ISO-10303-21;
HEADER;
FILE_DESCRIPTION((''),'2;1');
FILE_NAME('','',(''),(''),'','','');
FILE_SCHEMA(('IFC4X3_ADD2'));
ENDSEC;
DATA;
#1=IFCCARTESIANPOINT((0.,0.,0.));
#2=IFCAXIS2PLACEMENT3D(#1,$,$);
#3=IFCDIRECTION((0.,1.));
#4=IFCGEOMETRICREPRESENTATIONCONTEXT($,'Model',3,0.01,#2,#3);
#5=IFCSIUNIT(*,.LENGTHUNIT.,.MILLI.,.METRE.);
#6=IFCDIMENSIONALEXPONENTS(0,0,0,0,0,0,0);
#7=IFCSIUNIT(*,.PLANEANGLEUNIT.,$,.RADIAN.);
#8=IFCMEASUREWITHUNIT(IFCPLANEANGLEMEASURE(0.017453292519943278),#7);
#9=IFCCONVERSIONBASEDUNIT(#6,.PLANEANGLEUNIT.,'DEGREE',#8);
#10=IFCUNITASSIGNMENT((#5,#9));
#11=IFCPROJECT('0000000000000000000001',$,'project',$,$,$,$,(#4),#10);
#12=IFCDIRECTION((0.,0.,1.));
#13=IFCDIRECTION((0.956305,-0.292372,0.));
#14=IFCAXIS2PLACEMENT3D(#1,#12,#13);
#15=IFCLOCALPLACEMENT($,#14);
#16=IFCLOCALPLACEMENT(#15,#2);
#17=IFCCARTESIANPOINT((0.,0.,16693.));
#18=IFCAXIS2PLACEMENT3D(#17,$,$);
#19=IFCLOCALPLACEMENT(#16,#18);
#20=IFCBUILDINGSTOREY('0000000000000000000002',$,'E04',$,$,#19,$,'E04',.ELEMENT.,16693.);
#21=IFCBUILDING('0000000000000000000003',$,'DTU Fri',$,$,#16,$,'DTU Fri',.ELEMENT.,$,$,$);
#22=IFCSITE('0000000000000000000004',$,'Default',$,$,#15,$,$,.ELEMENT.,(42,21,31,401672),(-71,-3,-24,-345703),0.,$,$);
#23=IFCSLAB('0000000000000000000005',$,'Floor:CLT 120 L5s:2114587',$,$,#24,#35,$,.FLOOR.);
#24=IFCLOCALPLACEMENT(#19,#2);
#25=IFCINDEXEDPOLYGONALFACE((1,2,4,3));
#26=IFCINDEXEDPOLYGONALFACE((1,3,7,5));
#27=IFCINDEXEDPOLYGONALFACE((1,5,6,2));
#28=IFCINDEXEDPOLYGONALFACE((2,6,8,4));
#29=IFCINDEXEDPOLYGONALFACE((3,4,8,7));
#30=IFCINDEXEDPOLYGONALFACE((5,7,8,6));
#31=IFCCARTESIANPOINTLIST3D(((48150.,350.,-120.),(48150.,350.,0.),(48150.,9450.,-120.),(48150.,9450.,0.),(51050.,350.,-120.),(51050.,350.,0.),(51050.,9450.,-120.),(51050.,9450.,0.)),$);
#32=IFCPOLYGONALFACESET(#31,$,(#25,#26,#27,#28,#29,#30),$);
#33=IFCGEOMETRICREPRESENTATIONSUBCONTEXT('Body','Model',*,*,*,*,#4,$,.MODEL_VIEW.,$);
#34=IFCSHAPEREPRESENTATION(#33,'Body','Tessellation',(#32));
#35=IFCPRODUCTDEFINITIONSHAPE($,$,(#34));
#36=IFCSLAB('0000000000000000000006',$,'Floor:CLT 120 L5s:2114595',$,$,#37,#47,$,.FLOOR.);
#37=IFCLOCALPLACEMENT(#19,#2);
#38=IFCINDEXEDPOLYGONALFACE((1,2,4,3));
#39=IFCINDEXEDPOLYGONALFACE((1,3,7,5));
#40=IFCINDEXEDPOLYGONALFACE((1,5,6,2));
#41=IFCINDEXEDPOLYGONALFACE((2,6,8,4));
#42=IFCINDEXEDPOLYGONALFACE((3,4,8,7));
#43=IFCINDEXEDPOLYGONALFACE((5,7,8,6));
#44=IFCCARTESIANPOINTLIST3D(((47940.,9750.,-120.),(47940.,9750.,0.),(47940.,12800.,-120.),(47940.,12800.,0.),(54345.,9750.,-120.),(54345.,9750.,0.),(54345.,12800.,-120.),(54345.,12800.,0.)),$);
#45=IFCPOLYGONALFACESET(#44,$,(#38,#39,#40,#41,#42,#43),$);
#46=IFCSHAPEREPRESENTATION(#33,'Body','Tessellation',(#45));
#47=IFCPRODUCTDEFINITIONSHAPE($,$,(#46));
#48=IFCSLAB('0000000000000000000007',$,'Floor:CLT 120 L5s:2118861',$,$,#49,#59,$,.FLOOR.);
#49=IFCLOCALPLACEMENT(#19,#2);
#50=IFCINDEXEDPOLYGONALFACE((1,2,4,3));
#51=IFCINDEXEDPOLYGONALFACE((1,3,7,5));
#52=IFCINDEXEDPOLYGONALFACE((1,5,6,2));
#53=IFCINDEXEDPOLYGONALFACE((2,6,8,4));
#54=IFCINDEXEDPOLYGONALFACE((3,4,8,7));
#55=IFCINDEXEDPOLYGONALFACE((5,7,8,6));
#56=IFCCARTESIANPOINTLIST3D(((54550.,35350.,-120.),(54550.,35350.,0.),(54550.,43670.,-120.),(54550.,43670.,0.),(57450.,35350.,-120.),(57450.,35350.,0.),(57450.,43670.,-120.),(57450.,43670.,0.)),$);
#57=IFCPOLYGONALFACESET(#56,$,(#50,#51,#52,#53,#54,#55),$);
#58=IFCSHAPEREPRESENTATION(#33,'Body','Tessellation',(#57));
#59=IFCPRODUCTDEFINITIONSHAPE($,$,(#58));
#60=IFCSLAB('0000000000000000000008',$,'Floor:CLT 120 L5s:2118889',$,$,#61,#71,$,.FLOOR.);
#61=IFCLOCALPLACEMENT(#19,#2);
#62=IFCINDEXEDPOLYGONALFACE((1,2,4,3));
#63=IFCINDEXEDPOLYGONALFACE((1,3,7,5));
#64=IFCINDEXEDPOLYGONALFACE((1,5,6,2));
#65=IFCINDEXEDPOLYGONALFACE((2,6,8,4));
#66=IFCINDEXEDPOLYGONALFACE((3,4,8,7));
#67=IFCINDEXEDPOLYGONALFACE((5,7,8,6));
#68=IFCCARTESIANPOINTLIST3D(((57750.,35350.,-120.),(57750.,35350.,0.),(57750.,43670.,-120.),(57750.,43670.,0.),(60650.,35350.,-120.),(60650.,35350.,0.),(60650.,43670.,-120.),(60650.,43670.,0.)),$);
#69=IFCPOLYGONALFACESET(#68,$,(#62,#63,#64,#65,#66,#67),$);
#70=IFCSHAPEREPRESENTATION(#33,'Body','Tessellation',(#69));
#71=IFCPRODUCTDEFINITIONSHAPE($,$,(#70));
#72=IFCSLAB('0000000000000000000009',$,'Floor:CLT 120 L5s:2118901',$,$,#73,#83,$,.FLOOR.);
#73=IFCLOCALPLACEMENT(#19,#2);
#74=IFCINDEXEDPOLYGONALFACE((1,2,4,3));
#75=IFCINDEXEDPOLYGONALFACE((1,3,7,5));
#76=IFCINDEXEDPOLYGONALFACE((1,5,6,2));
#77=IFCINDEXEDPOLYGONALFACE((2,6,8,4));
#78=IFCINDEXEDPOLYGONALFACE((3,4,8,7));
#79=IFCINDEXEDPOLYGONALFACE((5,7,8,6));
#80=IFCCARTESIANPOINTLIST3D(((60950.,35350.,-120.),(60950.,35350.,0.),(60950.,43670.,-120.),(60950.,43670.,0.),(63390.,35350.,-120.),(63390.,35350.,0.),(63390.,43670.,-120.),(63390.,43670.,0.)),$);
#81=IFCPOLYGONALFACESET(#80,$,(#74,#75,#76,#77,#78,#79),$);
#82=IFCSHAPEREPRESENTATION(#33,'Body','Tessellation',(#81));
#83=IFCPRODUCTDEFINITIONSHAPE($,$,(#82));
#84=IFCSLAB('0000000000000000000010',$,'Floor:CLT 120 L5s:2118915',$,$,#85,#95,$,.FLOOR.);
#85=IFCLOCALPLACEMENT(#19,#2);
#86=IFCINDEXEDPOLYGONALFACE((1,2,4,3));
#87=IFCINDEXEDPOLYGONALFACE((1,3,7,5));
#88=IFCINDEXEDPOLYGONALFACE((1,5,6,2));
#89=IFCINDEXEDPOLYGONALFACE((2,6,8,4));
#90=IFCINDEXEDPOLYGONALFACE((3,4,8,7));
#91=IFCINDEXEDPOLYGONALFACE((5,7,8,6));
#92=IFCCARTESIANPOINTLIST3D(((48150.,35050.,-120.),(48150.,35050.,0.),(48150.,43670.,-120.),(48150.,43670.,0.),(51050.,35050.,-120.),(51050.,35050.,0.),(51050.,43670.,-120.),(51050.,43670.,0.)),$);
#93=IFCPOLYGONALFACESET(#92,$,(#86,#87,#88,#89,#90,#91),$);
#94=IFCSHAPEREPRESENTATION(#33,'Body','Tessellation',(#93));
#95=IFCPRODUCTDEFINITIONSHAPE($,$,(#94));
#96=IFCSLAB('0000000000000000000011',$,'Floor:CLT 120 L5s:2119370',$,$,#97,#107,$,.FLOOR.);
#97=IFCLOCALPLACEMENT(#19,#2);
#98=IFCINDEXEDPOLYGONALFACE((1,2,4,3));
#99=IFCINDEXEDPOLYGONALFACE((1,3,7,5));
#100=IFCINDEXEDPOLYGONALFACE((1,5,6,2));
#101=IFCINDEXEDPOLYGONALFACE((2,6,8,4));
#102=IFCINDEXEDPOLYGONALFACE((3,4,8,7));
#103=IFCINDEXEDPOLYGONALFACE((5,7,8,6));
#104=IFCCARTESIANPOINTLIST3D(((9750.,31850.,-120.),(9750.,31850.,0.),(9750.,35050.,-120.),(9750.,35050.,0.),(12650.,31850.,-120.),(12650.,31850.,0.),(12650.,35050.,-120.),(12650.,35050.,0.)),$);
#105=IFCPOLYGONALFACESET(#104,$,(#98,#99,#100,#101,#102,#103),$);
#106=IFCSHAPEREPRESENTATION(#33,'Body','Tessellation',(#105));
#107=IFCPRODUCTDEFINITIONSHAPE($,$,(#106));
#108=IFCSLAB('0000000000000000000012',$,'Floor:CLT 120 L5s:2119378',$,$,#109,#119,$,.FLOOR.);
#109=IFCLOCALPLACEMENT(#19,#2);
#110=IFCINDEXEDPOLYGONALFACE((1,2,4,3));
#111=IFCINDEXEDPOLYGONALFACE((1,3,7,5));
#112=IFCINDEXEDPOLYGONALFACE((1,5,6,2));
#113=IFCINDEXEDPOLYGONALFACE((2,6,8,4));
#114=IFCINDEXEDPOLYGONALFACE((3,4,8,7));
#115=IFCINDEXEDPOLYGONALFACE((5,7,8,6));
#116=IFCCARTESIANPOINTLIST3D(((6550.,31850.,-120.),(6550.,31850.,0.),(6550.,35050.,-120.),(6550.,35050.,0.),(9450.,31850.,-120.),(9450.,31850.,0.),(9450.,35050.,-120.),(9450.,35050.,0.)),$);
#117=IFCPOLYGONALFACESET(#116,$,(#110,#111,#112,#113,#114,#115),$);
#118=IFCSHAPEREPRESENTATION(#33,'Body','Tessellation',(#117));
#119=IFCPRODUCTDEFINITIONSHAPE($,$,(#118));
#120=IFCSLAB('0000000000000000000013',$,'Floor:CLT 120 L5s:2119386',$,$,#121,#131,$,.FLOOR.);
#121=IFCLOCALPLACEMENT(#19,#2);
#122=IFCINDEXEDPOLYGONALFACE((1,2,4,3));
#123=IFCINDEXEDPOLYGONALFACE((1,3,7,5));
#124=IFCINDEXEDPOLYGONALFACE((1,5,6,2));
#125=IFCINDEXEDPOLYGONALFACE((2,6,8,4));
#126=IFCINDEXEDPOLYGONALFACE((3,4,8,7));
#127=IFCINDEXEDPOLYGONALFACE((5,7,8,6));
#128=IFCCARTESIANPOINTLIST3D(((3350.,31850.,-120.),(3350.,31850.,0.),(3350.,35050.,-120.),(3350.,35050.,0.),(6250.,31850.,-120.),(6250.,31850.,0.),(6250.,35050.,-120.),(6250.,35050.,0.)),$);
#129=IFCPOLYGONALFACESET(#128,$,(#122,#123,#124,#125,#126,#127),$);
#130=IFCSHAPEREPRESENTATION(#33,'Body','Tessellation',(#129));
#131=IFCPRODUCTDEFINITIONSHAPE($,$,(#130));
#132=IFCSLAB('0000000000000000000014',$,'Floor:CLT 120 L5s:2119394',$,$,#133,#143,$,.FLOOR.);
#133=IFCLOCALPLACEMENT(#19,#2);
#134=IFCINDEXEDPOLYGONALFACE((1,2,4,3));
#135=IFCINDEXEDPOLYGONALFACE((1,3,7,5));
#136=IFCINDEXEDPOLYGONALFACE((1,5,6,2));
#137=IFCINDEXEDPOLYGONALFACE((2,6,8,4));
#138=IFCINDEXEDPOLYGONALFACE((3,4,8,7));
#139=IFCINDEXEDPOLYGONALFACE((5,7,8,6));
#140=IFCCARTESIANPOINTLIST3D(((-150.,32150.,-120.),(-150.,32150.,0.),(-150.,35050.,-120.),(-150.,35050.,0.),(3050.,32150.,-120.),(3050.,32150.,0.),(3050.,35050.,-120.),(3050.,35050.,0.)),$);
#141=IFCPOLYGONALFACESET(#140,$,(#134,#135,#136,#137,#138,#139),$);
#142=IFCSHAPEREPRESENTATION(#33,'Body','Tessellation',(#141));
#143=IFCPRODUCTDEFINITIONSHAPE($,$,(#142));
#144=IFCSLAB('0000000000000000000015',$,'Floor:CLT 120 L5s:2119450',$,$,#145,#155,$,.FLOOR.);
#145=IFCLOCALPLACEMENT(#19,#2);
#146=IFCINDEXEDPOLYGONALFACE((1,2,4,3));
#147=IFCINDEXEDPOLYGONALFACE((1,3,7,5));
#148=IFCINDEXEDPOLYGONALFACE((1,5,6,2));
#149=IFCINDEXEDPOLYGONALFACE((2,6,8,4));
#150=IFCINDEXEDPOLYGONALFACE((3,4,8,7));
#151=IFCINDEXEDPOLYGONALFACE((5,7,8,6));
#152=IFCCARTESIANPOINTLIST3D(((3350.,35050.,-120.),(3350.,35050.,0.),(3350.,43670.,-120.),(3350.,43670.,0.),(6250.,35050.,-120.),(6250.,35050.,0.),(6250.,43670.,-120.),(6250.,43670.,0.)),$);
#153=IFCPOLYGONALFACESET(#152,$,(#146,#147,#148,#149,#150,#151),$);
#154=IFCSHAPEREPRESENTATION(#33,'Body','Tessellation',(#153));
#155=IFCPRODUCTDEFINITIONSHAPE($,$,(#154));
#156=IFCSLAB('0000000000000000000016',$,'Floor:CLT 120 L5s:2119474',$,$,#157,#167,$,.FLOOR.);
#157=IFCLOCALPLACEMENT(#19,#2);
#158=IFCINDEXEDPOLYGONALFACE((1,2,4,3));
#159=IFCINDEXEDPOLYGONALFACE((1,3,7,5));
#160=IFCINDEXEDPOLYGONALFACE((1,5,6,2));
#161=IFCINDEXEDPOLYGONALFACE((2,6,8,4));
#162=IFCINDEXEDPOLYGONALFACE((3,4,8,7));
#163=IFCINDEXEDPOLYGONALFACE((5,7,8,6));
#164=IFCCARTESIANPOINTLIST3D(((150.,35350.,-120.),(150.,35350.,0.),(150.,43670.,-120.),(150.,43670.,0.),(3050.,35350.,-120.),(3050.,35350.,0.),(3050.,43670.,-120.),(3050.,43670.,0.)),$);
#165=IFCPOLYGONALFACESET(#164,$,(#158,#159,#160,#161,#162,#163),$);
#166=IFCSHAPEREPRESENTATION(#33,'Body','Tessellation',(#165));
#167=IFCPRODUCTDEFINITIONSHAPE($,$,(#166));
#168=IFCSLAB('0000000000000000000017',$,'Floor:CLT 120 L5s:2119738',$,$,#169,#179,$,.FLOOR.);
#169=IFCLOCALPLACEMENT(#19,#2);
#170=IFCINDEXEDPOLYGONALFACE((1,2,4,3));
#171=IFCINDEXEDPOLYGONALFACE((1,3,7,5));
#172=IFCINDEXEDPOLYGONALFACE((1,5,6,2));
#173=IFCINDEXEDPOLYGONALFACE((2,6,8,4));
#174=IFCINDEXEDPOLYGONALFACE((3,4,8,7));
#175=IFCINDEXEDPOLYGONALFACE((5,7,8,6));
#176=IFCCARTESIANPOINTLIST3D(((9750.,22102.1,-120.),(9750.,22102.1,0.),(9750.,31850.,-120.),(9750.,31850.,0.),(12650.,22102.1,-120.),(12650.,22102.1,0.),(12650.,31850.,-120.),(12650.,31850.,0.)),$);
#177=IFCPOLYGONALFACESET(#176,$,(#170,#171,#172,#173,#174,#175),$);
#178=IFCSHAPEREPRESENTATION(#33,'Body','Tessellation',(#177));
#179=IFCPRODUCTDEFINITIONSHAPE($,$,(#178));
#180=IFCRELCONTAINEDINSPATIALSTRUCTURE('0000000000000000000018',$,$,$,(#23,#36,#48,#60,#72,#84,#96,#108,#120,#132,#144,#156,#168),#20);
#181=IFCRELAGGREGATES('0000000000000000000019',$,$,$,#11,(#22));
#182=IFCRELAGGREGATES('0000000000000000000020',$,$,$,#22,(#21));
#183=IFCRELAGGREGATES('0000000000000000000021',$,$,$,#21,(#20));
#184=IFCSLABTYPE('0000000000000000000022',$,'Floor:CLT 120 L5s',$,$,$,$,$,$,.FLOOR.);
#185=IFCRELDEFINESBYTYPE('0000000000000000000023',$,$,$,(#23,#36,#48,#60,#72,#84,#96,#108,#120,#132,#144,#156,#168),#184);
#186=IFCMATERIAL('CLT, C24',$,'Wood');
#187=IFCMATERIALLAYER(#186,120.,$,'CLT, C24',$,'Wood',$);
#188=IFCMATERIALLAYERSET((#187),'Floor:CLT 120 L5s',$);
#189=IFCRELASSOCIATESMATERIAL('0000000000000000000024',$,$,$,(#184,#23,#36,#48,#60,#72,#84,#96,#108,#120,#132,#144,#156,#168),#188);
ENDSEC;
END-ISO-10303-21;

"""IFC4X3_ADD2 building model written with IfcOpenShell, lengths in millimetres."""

from ifc_helpers import new_model, entity, si_unit, converted_unit, direction, frame, frame_2d, origin, place, context, subcontext, project, spatial, rectangle, extrude, material, layer, layer_set, layer_usage, type_object, element, save


model = new_model("IFC4X3_ADD2")

# Units and contexts
model_context = context("Model", 3, precision=0.01, world=origin(), true_north=direction((0.0, 1.0)))
body_context = subcontext(model_context, "Body", "Model", "MODEL_VIEW")
ifc_project = project(units=[si_unit("LENGTHUNIT", "METRE", prefix="MILLI"), converted_unit("PLANEANGLEUNIT", "DEGREE", entity("IfcPlaneAngleMeasure", 0.017453292519943278), si_unit("PLANEANGLEUNIT", "RADIAN"), dimensions=[0, 0, 0, 0, 0, 0, 0])], contexts=[model_context])

# Site, building, storey
site_placement = place(None, frame((0.0, 0.0, 0.0), z_axis=(0.0, 0.0, 1.0), x_axis=(0.956305, -0.292372, 0.0)))
site = spatial("IfcSite", under=ifc_project, at=site_placement, Name="Default", CompositionType="ELEMENT", RefLatitude=(42, 21, 31, 401672), RefLongitude=(-71, -3, -24, -345703), RefElevation=0.0)
building_placement = place(site_placement, origin())
building = spatial("IfcBuilding", under=site, at=building_placement, Name="DTU Fri", LongName="DTU Fri", CompositionType="ELEMENT")
storey_placement = place(building_placement, frame((0.0, 0.0, 16693.0)))
storey = spatial("IfcBuildingStorey", under=building, at=storey_placement, Name="E04", LongName="E04", CompositionType="ELEMENT", Elevation=16693.0)

# Slabs
ifc_material = material(Name="CLT, C24", Category="Wood")
ifc_layer = layer(ifc_material, 120.0, Name="CLT, C24", Category="Wood")
ifc_layer_set = layer_set([ifc_layer], Name="Floor:CLT 120 L5s")
ifc_layer_usage_1 = layer_usage(ifc_layer_set, "AXIS3", "POSITIVE", 0.0)
slab_type = type_object("IfcSlabType", Name="Floor:CLT 120 L5s", PredefinedType="FLOOR", material=ifc_layer_set)
slab_1_placement = place(storey_placement, origin())
element("IfcSlab", 1, at=slab_1_placement, inside=storey, type_object=slab_type, material=ifc_layer_usage_1, Name="Floor:CLT 120 L5s:2114587", PredefinedType="FLOOR", context=body_context, shape_type="SweptSolid", body=[
    extrude(rectangle(XDim=9100.0, YDim=2900.0, at=frame_2d((0.0, 0.0), x_axis=(1.0, 0.0))), frame((49600.0, 4900.0, 0.0), z_axis=(0.0, 0.0, -1.0), x_axis=(0.0, 1.0, 0.0)), (0.0, 0.0, 1.0), 120.0),
])
ifc_layer_usage_2 = layer_usage(ifc_layer_set, "AXIS3", "POSITIVE", 0.0)
slab_2_placement = place(storey_placement, origin())
element("IfcSlab", 2, at=slab_2_placement, inside=storey, type_object=slab_type, material=ifc_layer_usage_2, Name="Floor:CLT 120 L5s:2114595", PredefinedType="FLOOR", context=body_context, shape_type="SweptSolid", body=[
    extrude(rectangle(XDim=3050.0, YDim=6405.0, at=frame_2d((0.0, 0.0), x_axis=(1.0, 0.0))), frame((51142.5, 11275.0, 0.0), z_axis=(0.0, 0.0, -1.0), x_axis=(0.0, 1.0, 0.0)), (0.0, 0.0, 1.0), 120.0),
])
ifc_layer_usage_3 = layer_usage(ifc_layer_set, "AXIS3", "POSITIVE", 0.0)
slab_3_placement = place(storey_placement, origin())
element("IfcSlab", 3, at=slab_3_placement, inside=storey, type_object=slab_type, material=ifc_layer_usage_3, Name="Floor:CLT 120 L5s:2118861", PredefinedType="FLOOR", context=body_context, shape_type="SweptSolid", body=[
    extrude(rectangle(XDim=8320.0, YDim=2900.0, at=frame_2d((0.0, 0.0), x_axis=(1.0, 0.0))), frame((56000.0, 39510.0, 0.0), z_axis=(0.0, 0.0, -1.0), x_axis=(0.0, 1.0, 0.0)), (0.0, 0.0, 1.0), 120.0),
])
ifc_layer_usage_4 = layer_usage(ifc_layer_set, "AXIS3", "POSITIVE", 0.0)
slab_4_placement = place(storey_placement, origin())
element("IfcSlab", 4, at=slab_4_placement, inside=storey, type_object=slab_type, material=ifc_layer_usage_4, Name="Floor:CLT 120 L5s:2118889", PredefinedType="FLOOR", context=body_context, shape_type="SweptSolid", body=[
    extrude(rectangle(XDim=8320.0, YDim=2900.0, at=frame_2d((0.0, 0.0), x_axis=(1.0, 0.0))), frame((59200.0, 39510.0, 0.0), z_axis=(0.0, 0.0, -1.0), x_axis=(0.0, 1.0, 0.0)), (0.0, 0.0, 1.0), 120.0),
])
ifc_layer_usage_5 = layer_usage(ifc_layer_set, "AXIS3", "POSITIVE", 0.0)
slab_5_placement = place(storey_placement, origin())
element("IfcSlab", 5, at=slab_5_placement, inside=storey, type_object=slab_type, material=ifc_layer_usage_5, Name="Floor:CLT 120 L5s:2118901", PredefinedType="FLOOR", context=body_context, shape_type="SweptSolid", body=[
    extrude(rectangle(XDim=8320.0, YDim=2440.0, at=frame_2d((0.0, 0.0), x_axis=(1.0, 0.0))), frame((62170.0, 39510.0, 0.0), z_axis=(0.0, 0.0, -1.0), x_axis=(0.0, 1.0, 0.0)), (0.0, 0.0, 1.0), 120.0),
])
ifc_layer_usage_6 = layer_usage(ifc_layer_set, "AXIS3", "POSITIVE", 0.0)
slab_6_placement = place(storey_placement, origin())
element("IfcSlab", 6, at=slab_6_placement, inside=storey, type_object=slab_type, material=ifc_layer_usage_6, Name="Floor:CLT 120 L5s:2118915", PredefinedType="FLOOR", context=body_context, shape_type="SweptSolid", body=[
    extrude(rectangle(XDim=8620.0, YDim=2900.0, at=frame_2d((0.0, 0.0), x_axis=(1.0, 0.0))), frame((49600.0, 39360.0, 0.0), z_axis=(0.0, 0.0, -1.0), x_axis=(0.0, 1.0, 0.0)), (0.0, 0.0, 1.0), 120.0),
])
ifc_layer_usage_7 = layer_usage(ifc_layer_set, "AXIS3", "POSITIVE", 0.0)
slab_7_placement = place(storey_placement, origin())
element("IfcSlab", 7, at=slab_7_placement, inside=storey, type_object=slab_type, material=ifc_layer_usage_7, Name="Floor:CLT 120 L5s:2119370", PredefinedType="FLOOR", context=body_context, shape_type="SweptSolid", body=[
    extrude(rectangle(XDim=3200.0, YDim=2900.0, at=frame_2d((0.0, 0.0), x_axis=(1.0, 0.0))), frame((11200.0, 33450.0, 0.0), z_axis=(0.0, 0.0, -1.0), x_axis=(0.0, 1.0, 0.0)), (0.0, 0.0, 1.0), 120.0),
])
ifc_layer_usage_8 = layer_usage(ifc_layer_set, "AXIS3", "POSITIVE", 0.0)
slab_8_placement = place(storey_placement, origin())
element("IfcSlab", 8, at=slab_8_placement, inside=storey, type_object=slab_type, material=ifc_layer_usage_8, Name="Floor:CLT 120 L5s:2119378", PredefinedType="FLOOR", context=body_context, shape_type="SweptSolid", body=[
    extrude(rectangle(XDim=3200.0, YDim=2900.0, at=frame_2d((0.0, 0.0), x_axis=(1.0, 0.0))), frame((8000.0, 33450.0, 0.0), z_axis=(0.0, 0.0, -1.0), x_axis=(0.0, 1.0, 0.0)), (0.0, 0.0, 1.0), 120.0),
])
ifc_layer_usage_9 = layer_usage(ifc_layer_set, "AXIS3", "POSITIVE", 0.0)
slab_9_placement = place(storey_placement, origin())
element("IfcSlab", 9, at=slab_9_placement, inside=storey, type_object=slab_type, material=ifc_layer_usage_9, Name="Floor:CLT 120 L5s:2119386", PredefinedType="FLOOR", context=body_context, shape_type="SweptSolid", body=[
    extrude(rectangle(XDim=3200.0, YDim=2900.0, at=frame_2d((0.0, 0.0), x_axis=(1.0, 0.0))), frame((4800.0, 33450.0, 0.0), z_axis=(0.0, 0.0, -1.0), x_axis=(0.0, 1.0, 0.0)), (0.0, 0.0, 1.0), 120.0),
])
ifc_layer_usage_10 = layer_usage(ifc_layer_set, "AXIS3", "POSITIVE", 0.0)
slab_10_placement = place(storey_placement, origin())
element("IfcSlab", 10, at=slab_10_placement, inside=storey, type_object=slab_type, material=ifc_layer_usage_10, Name="Floor:CLT 120 L5s:2119394", PredefinedType="FLOOR", context=body_context, shape_type="SweptSolid", body=[
    extrude(rectangle(XDim=2900.0, YDim=3200.0, at=frame_2d((0.0, 0.0), x_axis=(1.0, 0.0))), frame((1450.0, 33600.0, 0.0), z_axis=(0.0, 0.0, -1.0), x_axis=(0.0, 1.0, 0.0)), (0.0, 0.0, 1.0), 120.0),
])
ifc_layer_usage_11 = layer_usage(ifc_layer_set, "AXIS3", "POSITIVE", 0.0)
slab_11_placement = place(storey_placement, origin())
element("IfcSlab", 11, at=slab_11_placement, inside=storey, type_object=slab_type, material=ifc_layer_usage_11, Name="Floor:CLT 120 L5s:2119450", PredefinedType="FLOOR", context=body_context, shape_type="SweptSolid", body=[
    extrude(rectangle(XDim=8620.0, YDim=2900.0, at=frame_2d((0.0, 0.0), x_axis=(1.0, 0.0))), frame((4800.0, 39360.0, 0.0), z_axis=(0.0, 0.0, -1.0), x_axis=(0.0, 1.0, 0.0)), (0.0, 0.0, 1.0), 120.0),
])
ifc_layer_usage_12 = layer_usage(ifc_layer_set, "AXIS3", "POSITIVE", 0.0)
slab_12_placement = place(storey_placement, origin())
element("IfcSlab", 12, at=slab_12_placement, inside=storey, type_object=slab_type, material=ifc_layer_usage_12, Name="Floor:CLT 120 L5s:2119474", PredefinedType="FLOOR", context=body_context, shape_type="SweptSolid", body=[
    extrude(rectangle(XDim=8320.0, YDim=2900.0, at=frame_2d((0.0, 0.0), x_axis=(1.0, 0.0))), frame((1600.0, 39510.0, 0.0), z_axis=(0.0, 0.0, -1.0), x_axis=(0.0, 1.0, 0.0)), (0.0, 0.0, 1.0), 120.0),
])
ifc_layer_usage_13 = layer_usage(ifc_layer_set, "AXIS3", "POSITIVE", 0.0)
slab_13_placement = place(storey_placement, origin())
element("IfcSlab", 13, at=slab_13_placement, inside=storey, type_object=slab_type, material=ifc_layer_usage_13, Name="Floor:CLT 120 L5s:2119738", PredefinedType="FLOOR", context=body_context, shape_type="SweptSolid", body=[
    extrude(rectangle(XDim=9747.9, YDim=2900.0, at=frame_2d((0.0, 0.0), x_axis=(1.0, 0.0))), frame((11200.0, 26976.0, 0.0), z_axis=(0.0, 0.0, -1.0), x_axis=(0.0, 1.0, 0.0)), (0.0, 0.0, 1.0), 120.0),
])

save(model, "model.ifc")
